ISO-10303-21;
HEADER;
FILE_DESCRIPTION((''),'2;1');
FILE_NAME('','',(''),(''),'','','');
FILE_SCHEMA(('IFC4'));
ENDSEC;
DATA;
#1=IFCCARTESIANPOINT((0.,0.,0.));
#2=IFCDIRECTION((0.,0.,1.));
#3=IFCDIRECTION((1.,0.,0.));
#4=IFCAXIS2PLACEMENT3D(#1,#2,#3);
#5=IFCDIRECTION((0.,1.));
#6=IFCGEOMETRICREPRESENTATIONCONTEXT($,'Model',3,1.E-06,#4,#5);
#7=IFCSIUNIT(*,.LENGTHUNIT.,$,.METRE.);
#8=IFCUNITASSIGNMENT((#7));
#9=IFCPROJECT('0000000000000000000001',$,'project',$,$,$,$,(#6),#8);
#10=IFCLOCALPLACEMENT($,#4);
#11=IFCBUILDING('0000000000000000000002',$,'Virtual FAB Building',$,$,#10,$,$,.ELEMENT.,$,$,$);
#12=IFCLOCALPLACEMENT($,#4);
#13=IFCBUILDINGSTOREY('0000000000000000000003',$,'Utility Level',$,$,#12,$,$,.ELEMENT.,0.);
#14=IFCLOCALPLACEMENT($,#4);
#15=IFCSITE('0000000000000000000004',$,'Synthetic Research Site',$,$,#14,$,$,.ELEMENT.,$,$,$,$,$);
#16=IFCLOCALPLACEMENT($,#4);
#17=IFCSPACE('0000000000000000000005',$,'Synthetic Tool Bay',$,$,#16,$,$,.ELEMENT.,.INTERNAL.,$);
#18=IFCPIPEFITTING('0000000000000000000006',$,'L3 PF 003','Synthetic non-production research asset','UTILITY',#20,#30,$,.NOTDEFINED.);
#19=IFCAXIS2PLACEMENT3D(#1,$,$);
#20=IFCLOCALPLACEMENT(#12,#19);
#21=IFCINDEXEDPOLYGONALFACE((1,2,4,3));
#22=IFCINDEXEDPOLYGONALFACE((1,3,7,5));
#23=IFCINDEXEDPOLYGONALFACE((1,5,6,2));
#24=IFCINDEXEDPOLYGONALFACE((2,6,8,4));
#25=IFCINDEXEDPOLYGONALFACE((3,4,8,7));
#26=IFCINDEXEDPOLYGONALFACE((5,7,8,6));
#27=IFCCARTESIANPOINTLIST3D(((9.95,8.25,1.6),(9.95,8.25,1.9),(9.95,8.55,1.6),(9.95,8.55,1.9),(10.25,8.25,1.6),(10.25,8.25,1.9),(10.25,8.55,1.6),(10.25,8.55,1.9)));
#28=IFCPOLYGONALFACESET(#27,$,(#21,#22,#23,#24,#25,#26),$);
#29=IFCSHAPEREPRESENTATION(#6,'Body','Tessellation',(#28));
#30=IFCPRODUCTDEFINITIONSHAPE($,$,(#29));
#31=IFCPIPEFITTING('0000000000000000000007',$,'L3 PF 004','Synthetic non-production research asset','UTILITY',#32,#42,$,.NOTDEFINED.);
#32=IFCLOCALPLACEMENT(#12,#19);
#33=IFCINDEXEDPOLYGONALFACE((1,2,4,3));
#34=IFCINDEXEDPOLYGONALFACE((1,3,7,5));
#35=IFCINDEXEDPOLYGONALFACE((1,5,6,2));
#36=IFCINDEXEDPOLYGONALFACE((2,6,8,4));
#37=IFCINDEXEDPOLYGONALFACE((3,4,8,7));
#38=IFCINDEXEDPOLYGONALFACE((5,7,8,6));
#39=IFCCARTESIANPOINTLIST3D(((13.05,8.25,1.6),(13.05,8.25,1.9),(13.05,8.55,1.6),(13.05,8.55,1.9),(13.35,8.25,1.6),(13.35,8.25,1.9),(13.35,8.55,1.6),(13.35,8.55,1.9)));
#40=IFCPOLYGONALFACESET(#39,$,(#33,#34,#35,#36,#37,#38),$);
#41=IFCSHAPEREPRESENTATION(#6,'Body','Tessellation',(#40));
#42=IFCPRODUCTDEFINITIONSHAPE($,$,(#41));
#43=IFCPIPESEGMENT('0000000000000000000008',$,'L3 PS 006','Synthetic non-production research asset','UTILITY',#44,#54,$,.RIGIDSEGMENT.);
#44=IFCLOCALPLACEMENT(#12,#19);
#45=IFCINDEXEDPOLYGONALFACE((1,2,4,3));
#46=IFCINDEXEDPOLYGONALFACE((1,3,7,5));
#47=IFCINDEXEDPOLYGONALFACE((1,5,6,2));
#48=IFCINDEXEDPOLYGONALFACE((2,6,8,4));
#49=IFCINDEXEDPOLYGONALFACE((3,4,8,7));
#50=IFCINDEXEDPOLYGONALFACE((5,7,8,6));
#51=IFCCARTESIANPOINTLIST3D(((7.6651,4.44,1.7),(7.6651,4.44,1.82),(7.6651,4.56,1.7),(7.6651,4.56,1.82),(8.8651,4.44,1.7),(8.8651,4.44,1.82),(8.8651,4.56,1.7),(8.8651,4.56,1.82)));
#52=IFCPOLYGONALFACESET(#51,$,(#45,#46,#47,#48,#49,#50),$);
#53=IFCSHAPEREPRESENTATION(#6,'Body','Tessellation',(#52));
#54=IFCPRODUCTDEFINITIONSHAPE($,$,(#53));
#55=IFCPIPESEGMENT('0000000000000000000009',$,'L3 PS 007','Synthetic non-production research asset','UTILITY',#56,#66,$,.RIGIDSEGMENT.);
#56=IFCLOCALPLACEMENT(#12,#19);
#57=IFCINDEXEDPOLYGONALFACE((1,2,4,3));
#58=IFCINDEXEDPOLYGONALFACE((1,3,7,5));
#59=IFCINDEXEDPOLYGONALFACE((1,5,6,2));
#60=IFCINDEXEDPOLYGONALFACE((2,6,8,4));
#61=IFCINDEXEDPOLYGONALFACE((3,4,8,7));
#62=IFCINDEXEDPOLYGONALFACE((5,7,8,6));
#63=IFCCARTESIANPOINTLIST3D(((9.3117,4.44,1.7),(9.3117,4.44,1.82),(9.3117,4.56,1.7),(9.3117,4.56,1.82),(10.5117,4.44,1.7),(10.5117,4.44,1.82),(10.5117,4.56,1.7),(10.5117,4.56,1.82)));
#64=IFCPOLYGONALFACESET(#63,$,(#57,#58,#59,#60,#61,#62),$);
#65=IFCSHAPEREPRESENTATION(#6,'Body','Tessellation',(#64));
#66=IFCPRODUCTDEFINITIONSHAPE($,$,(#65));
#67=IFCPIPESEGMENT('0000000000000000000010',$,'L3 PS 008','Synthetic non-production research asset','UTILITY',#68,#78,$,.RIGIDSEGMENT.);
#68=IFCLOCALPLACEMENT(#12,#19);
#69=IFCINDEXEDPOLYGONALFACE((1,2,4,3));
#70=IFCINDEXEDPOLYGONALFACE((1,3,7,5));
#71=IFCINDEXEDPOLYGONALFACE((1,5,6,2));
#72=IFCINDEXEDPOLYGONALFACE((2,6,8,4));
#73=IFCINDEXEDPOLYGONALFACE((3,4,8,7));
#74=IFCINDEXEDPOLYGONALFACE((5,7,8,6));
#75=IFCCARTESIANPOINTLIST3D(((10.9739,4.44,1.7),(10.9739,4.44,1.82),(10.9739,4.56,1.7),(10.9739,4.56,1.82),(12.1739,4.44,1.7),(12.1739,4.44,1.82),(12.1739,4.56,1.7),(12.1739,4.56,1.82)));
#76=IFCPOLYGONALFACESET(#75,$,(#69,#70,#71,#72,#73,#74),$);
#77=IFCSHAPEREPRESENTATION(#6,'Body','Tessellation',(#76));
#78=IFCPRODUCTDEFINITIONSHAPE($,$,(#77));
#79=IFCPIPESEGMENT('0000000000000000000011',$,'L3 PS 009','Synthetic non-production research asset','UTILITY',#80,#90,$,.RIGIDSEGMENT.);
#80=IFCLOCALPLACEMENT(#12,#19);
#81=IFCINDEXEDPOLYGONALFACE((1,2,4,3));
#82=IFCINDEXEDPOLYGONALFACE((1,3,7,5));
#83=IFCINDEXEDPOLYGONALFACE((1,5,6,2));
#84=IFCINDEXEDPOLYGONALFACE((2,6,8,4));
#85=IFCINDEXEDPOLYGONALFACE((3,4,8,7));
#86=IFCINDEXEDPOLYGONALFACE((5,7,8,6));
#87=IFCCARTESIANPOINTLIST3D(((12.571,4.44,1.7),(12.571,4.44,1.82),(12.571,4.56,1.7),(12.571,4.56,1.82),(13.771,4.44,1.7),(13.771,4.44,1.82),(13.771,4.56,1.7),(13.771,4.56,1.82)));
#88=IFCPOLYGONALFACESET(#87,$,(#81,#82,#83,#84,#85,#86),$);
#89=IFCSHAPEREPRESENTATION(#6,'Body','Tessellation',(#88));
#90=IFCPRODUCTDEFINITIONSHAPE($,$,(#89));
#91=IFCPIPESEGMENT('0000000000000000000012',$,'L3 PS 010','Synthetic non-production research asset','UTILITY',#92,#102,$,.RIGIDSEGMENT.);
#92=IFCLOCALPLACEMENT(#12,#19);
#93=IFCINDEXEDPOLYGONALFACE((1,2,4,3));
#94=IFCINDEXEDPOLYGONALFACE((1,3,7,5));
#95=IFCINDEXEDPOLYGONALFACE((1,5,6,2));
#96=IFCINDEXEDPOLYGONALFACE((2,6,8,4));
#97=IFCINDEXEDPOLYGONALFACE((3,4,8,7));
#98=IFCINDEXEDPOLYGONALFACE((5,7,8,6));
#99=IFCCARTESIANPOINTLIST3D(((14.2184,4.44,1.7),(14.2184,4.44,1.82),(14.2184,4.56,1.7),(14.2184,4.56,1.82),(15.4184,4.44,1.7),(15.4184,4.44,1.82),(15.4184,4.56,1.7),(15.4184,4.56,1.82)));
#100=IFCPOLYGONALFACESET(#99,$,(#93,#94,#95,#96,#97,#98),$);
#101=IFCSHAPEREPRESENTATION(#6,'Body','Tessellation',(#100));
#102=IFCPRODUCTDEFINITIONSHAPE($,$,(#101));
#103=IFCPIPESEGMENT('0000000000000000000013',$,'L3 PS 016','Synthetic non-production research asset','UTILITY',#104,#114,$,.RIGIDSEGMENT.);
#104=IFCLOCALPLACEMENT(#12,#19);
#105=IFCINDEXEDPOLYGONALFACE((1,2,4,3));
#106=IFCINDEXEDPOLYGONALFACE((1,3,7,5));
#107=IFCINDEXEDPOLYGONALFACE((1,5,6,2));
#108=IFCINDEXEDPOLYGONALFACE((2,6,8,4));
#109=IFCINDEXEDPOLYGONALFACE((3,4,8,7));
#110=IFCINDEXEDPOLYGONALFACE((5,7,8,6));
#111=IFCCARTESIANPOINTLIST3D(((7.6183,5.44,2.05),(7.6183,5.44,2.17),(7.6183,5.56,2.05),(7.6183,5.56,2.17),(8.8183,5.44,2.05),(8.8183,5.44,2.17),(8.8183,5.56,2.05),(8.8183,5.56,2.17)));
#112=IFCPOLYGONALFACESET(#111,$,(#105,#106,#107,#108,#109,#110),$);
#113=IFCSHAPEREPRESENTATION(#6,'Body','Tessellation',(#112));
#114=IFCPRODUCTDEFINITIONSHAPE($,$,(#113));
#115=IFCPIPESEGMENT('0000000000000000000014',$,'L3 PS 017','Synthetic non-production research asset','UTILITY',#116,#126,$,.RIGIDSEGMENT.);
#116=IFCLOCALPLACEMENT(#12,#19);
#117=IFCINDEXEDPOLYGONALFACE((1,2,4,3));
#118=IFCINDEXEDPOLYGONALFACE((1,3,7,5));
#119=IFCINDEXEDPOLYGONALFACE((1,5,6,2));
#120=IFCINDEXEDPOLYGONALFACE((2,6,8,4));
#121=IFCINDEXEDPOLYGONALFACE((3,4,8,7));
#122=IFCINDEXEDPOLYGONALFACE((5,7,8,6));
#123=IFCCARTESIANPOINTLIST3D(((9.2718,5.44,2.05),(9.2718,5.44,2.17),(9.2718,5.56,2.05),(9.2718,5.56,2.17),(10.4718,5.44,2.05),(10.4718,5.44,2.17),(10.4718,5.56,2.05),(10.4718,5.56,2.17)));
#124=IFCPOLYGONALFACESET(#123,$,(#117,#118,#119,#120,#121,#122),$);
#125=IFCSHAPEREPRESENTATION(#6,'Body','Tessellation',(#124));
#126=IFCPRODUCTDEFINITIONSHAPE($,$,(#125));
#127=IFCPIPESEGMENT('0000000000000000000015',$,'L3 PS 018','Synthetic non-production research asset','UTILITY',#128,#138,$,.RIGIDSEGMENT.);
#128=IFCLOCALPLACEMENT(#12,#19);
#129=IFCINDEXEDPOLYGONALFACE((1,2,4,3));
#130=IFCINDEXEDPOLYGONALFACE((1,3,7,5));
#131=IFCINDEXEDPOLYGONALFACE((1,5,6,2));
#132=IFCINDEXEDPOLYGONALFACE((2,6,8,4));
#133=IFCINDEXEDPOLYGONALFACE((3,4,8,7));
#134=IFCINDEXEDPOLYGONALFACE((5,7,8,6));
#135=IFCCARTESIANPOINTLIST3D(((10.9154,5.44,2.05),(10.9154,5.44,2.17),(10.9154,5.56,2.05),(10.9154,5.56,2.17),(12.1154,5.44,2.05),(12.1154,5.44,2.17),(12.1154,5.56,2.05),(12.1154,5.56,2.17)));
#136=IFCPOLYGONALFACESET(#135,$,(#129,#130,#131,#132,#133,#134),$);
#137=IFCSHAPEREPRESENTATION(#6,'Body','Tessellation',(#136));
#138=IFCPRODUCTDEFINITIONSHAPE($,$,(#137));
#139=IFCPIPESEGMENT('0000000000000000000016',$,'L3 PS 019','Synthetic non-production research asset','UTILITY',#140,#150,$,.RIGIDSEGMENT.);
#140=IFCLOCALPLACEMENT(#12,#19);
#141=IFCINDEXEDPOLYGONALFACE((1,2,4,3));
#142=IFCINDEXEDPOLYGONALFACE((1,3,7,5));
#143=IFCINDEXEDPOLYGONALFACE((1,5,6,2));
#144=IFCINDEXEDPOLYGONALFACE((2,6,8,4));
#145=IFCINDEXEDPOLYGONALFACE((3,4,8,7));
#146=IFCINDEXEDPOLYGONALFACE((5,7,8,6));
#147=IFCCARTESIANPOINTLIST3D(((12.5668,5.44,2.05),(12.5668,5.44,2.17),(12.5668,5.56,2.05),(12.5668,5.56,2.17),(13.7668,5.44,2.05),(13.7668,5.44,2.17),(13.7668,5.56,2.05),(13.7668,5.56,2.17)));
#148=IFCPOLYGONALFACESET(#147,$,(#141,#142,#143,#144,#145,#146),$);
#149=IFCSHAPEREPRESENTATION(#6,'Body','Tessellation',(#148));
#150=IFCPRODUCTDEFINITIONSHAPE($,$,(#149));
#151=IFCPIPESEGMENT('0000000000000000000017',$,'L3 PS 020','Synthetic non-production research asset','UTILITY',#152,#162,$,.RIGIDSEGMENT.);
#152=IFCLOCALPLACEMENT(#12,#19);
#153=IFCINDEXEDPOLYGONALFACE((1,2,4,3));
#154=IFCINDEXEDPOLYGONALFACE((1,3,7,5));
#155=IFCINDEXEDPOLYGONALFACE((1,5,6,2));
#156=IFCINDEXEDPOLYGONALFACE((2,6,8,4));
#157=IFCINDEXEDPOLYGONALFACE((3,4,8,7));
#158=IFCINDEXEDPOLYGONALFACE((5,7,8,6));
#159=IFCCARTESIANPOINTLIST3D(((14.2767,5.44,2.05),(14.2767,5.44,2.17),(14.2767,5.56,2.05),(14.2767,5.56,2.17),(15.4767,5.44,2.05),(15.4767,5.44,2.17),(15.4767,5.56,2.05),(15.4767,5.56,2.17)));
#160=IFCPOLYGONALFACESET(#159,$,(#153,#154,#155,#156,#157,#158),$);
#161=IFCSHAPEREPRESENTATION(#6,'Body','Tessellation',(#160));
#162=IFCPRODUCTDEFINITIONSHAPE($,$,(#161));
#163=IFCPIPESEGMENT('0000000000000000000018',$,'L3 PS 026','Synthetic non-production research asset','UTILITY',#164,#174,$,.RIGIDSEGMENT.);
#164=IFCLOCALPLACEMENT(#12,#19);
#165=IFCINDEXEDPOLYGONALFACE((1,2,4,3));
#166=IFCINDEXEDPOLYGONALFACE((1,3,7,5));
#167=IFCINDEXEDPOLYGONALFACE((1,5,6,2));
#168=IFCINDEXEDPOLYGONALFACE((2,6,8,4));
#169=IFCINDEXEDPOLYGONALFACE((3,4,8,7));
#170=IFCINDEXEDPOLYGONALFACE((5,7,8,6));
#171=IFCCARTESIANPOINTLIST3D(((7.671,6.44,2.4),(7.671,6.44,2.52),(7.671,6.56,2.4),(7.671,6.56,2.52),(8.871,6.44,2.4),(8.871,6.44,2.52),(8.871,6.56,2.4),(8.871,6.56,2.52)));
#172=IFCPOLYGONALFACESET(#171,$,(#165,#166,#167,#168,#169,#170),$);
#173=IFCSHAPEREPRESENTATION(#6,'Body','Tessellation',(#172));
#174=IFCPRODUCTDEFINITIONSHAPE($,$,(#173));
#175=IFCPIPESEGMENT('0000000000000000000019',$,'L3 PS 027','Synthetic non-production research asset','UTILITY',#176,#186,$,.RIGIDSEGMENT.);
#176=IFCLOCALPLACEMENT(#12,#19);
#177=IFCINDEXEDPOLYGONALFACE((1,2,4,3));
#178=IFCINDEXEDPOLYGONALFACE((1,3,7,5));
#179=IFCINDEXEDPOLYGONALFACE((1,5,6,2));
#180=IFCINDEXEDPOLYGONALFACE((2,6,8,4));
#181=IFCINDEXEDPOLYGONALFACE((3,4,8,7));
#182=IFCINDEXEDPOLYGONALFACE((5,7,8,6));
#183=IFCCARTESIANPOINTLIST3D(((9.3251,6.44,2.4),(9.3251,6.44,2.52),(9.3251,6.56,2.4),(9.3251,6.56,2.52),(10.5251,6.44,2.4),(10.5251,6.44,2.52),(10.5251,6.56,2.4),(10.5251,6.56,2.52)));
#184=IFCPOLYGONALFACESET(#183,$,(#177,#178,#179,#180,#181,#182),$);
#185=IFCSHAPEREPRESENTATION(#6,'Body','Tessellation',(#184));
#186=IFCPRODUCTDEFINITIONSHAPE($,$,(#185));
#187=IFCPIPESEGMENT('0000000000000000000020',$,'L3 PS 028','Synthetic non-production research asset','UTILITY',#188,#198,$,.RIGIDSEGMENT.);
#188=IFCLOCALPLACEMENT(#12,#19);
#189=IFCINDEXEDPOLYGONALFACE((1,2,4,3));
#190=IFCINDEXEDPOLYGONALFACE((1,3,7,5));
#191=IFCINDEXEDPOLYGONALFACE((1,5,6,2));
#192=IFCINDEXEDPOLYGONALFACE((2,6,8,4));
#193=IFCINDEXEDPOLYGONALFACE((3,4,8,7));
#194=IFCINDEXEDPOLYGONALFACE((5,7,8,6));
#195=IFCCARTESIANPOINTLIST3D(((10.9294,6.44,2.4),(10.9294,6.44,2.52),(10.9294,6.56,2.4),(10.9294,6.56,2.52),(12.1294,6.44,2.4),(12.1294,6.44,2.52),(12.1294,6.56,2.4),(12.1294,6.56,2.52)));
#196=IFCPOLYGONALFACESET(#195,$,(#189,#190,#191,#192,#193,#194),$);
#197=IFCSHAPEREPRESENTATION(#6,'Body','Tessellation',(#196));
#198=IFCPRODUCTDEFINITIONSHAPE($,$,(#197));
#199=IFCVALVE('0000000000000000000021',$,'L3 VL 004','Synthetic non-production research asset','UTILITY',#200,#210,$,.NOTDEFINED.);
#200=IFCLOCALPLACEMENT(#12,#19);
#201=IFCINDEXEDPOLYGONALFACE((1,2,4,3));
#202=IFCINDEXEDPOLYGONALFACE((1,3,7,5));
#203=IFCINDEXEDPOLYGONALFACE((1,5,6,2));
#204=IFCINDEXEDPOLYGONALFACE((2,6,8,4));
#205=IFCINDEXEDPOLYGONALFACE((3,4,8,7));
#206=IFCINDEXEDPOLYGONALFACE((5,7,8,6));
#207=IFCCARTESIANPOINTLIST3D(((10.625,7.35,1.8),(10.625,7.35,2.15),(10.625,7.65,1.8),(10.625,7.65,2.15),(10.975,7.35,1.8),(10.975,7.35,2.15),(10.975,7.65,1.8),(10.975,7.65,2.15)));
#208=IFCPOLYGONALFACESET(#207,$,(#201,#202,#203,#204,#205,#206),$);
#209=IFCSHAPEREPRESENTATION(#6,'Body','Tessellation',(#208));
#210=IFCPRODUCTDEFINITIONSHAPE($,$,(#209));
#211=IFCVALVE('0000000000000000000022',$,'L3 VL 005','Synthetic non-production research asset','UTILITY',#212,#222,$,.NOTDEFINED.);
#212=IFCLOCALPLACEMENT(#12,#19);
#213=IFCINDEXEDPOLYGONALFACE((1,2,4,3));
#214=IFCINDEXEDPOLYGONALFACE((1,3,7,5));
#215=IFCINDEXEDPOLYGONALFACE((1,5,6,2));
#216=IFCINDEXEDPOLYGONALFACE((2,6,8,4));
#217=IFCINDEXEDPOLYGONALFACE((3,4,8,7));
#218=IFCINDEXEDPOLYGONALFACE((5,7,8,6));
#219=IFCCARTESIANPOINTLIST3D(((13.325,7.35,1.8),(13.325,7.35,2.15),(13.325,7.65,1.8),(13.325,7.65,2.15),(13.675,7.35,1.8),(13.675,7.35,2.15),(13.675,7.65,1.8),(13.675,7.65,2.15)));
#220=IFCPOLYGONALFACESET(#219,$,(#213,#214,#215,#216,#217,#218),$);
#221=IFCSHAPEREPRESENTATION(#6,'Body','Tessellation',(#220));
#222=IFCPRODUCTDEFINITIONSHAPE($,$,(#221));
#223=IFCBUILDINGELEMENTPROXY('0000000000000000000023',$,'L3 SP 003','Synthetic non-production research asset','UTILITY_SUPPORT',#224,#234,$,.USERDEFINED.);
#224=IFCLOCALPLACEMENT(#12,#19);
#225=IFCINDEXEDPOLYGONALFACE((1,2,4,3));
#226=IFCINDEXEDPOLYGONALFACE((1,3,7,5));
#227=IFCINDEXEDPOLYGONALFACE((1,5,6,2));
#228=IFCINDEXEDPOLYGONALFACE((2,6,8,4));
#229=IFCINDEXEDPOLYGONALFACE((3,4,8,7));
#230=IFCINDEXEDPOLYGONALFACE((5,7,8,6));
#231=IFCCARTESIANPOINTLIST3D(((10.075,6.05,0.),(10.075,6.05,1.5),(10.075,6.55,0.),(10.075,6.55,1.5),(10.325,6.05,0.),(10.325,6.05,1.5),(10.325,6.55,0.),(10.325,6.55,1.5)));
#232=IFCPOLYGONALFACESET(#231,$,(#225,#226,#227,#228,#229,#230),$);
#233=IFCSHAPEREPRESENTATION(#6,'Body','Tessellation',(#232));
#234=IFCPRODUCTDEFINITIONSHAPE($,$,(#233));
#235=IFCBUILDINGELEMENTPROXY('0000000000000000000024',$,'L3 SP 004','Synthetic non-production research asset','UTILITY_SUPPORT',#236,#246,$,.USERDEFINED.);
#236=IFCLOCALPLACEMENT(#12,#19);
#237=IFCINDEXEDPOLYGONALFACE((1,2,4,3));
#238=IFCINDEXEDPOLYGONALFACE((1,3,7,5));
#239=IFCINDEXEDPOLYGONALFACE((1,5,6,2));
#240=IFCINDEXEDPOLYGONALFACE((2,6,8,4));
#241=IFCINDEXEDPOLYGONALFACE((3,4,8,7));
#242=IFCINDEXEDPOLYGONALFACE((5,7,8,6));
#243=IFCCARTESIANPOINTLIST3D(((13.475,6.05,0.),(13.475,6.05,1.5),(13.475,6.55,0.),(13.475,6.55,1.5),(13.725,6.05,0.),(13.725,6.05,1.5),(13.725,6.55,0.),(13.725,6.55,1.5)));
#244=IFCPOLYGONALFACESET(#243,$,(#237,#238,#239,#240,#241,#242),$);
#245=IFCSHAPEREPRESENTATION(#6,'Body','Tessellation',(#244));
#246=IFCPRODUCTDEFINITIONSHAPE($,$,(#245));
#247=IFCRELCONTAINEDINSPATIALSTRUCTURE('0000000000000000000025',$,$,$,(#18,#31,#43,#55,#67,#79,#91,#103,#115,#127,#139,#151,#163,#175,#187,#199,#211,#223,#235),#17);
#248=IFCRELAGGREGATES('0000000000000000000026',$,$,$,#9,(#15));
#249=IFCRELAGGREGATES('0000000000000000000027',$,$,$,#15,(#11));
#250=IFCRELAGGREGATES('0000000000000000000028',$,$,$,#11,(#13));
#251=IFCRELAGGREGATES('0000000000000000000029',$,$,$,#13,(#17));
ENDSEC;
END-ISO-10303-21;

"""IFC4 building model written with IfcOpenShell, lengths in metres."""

from ifc_helpers import new_model, si_unit, direction, frame, origin_with_axes, origin_2d_with_axis, place, context, project, spatial, rectangle, extrude, element, save


model = new_model("IFC4")

# Units and contexts
model_context = context("Model", 3, precision=1e-06, world=origin_with_axes(), true_north=direction((0.0, 1.0)))
ifc_project = project(units=[si_unit("LENGTHUNIT", "METRE")], contexts=[model_context])

# Site, building, storey, space
site_placement = place(None, origin_with_axes())
site = spatial("IfcSite", under=ifc_project, at=site_placement, Name="Synthetic Research Site", CompositionType="ELEMENT")
building_placement = place(None, origin_with_axes())
building = spatial("IfcBuilding", under=site, at=building_placement, Name="Virtual FAB Building", CompositionType="ELEMENT")
storey_placement = place(None, origin_with_axes())
storey = spatial("IfcBuildingStorey", under=building, at=storey_placement, Name="Utility Level", CompositionType="ELEMENT", Elevation=0.0)
space_placement = place(None, origin_with_axes())
space = spatial("IfcSpace", under=storey, at=space_placement, Name="Synthetic Tool Bay", CompositionType="ELEMENT", PredefinedType="INTERNAL")

# Pipe fittings
for number, where, z_axis, x_axis, name in (
    (1, (10.1, 8.4, 1.6), (0.0, 0.0, 1.0), (1.0, 0.0, 0.0), "L3 PF 003"),
    (2, (13.2, 8.4, 1.6), (0.0, 0.0, 1.0), (1.0, 0.0, 0.0), "L3 PF 004"),
):
    element("IfcPipeFitting", number, at=place(None, frame(where, z_axis=z_axis, x_axis=x_axis)), inside=space, Name=name, Description="Synthetic non-production research asset", ObjectType="UTILITY", PredefinedType="NOTDEFINED", context=model_context, shape_type="SweptSolid", body=[
        extrude(rectangle(XDim=0.3, YDim=0.3, at=origin_2d_with_axis()), origin_with_axes(), (0.0, 0.0, 1.0), 0.3),
    ])

# Pipe segments
for number, where, z_axis, x_axis, name in (
    (3, (8.2651, 4.5, 1.7), (0.0, 0.0, 1.0), (1.0, 0.0, 0.0), "L3 PS 006"),
    (4, (9.9117, 4.5, 1.7), (0.0, 0.0, 1.0), (1.0, 0.0, 0.0), "L3 PS 007"),
    (5, (11.5739, 4.5, 1.7), (0.0, 0.0, 1.0), (1.0, 0.0, 0.0), "L3 PS 008"),
    (6, (13.171, 4.5, 1.7), (0.0, 0.0, 1.0), (1.0, 0.0, 0.0), "L3 PS 009"),
    (7, (14.8184, 4.5, 1.7), (0.0, 0.0, 1.0), (1.0, 0.0, 0.0), "L3 PS 010"),
    (8, (8.2183, 5.5, 2.05), (0.0, 0.0, 1.0), (1.0, 0.0, 0.0), "L3 PS 016"),
    (9, (9.8718, 5.5, 2.05), (0.0, 0.0, 1.0), (1.0, 0.0, 0.0), "L3 PS 017"),
    (10, (11.5154, 5.5, 2.05), (0.0, 0.0, 1.0), (1.0, 0.0, 0.0), "L3 PS 018"),
    (11, (13.1668, 5.5, 2.05), (0.0, 0.0, 1.0), (1.0, 0.0, 0.0), "L3 PS 019"),
    (12, (14.8767, 5.5, 2.05), (0.0, 0.0, 1.0), (1.0, 0.0, 0.0), "L3 PS 020"),
    (13, (8.271, 6.5, 2.4), (0.0, 0.0, 1.0), (1.0, 0.0, 0.0), "L3 PS 026"),
    (14, (9.9251, 6.5, 2.4), (0.0, 0.0, 1.0), (1.0, 0.0, 0.0), "L3 PS 027"),
    (15, (11.5294, 6.5, 2.4), (0.0, 0.0, 1.0), (1.0, 0.0, 0.0), "L3 PS 028"),
):
    element("IfcPipeSegment", number, at=place(None, frame(where, z_axis=z_axis, x_axis=x_axis)), inside=space, Name=name, Description="Synthetic non-production research asset", ObjectType="UTILITY", PredefinedType="RIGIDSEGMENT", context=model_context, shape_type="SweptSolid", body=[
        extrude(rectangle(XDim=1.2, YDim=0.12, at=origin_2d_with_axis()), origin_with_axes(), (0.0, 0.0, 1.0), 0.12),
    ])

# Valves
for number, where, z_axis, x_axis, name in (
    (16, (10.8, 7.5, 1.8), (0.0, 0.0, 1.0), (1.0, 0.0, 0.0), "L3 VL 004"),
    (17, (13.5, 7.5, 1.8), (0.0, 0.0, 1.0), (1.0, 0.0, 0.0), "L3 VL 005"),
):
    element("IfcValve", number, at=place(None, frame(where, z_axis=z_axis, x_axis=x_axis)), inside=space, Name=name, Description="Synthetic non-production research asset", ObjectType="UTILITY", PredefinedType="NOTDEFINED", context=model_context, shape_type="SweptSolid", body=[
        extrude(rectangle(XDim=0.35, YDim=0.3, at=origin_2d_with_axis()), origin_with_axes(), (0.0, 0.0, 1.0), 0.35),
    ])

# Building element proxies
for number, where, z_axis, x_axis, name in (
    (18, (10.2, 6.3, 0.0), (0.0, 0.0, 1.0), (1.0, 0.0, 0.0), "L3 SP 003"),
    (19, (13.6, 6.3, 0.0), (0.0, 0.0, 1.0), (1.0, 0.0, 0.0), "L3 SP 004"),
):
    element("IfcBuildingElementProxy", number, at=place(None, frame(where, z_axis=z_axis, x_axis=x_axis)), inside=space, Name=name, Description="Synthetic non-production research asset", ObjectType="UTILITY_SUPPORT", PredefinedType="USERDEFINED", context=model_context, shape_type="SweptSolid", body=[
        extrude(rectangle(XDim=0.25, YDim=0.5, at=origin_2d_with_axis()), origin_with_axes(), (0.0, 0.0, 1.0), 1.5),
    ])

save(model, "model.ifc")
